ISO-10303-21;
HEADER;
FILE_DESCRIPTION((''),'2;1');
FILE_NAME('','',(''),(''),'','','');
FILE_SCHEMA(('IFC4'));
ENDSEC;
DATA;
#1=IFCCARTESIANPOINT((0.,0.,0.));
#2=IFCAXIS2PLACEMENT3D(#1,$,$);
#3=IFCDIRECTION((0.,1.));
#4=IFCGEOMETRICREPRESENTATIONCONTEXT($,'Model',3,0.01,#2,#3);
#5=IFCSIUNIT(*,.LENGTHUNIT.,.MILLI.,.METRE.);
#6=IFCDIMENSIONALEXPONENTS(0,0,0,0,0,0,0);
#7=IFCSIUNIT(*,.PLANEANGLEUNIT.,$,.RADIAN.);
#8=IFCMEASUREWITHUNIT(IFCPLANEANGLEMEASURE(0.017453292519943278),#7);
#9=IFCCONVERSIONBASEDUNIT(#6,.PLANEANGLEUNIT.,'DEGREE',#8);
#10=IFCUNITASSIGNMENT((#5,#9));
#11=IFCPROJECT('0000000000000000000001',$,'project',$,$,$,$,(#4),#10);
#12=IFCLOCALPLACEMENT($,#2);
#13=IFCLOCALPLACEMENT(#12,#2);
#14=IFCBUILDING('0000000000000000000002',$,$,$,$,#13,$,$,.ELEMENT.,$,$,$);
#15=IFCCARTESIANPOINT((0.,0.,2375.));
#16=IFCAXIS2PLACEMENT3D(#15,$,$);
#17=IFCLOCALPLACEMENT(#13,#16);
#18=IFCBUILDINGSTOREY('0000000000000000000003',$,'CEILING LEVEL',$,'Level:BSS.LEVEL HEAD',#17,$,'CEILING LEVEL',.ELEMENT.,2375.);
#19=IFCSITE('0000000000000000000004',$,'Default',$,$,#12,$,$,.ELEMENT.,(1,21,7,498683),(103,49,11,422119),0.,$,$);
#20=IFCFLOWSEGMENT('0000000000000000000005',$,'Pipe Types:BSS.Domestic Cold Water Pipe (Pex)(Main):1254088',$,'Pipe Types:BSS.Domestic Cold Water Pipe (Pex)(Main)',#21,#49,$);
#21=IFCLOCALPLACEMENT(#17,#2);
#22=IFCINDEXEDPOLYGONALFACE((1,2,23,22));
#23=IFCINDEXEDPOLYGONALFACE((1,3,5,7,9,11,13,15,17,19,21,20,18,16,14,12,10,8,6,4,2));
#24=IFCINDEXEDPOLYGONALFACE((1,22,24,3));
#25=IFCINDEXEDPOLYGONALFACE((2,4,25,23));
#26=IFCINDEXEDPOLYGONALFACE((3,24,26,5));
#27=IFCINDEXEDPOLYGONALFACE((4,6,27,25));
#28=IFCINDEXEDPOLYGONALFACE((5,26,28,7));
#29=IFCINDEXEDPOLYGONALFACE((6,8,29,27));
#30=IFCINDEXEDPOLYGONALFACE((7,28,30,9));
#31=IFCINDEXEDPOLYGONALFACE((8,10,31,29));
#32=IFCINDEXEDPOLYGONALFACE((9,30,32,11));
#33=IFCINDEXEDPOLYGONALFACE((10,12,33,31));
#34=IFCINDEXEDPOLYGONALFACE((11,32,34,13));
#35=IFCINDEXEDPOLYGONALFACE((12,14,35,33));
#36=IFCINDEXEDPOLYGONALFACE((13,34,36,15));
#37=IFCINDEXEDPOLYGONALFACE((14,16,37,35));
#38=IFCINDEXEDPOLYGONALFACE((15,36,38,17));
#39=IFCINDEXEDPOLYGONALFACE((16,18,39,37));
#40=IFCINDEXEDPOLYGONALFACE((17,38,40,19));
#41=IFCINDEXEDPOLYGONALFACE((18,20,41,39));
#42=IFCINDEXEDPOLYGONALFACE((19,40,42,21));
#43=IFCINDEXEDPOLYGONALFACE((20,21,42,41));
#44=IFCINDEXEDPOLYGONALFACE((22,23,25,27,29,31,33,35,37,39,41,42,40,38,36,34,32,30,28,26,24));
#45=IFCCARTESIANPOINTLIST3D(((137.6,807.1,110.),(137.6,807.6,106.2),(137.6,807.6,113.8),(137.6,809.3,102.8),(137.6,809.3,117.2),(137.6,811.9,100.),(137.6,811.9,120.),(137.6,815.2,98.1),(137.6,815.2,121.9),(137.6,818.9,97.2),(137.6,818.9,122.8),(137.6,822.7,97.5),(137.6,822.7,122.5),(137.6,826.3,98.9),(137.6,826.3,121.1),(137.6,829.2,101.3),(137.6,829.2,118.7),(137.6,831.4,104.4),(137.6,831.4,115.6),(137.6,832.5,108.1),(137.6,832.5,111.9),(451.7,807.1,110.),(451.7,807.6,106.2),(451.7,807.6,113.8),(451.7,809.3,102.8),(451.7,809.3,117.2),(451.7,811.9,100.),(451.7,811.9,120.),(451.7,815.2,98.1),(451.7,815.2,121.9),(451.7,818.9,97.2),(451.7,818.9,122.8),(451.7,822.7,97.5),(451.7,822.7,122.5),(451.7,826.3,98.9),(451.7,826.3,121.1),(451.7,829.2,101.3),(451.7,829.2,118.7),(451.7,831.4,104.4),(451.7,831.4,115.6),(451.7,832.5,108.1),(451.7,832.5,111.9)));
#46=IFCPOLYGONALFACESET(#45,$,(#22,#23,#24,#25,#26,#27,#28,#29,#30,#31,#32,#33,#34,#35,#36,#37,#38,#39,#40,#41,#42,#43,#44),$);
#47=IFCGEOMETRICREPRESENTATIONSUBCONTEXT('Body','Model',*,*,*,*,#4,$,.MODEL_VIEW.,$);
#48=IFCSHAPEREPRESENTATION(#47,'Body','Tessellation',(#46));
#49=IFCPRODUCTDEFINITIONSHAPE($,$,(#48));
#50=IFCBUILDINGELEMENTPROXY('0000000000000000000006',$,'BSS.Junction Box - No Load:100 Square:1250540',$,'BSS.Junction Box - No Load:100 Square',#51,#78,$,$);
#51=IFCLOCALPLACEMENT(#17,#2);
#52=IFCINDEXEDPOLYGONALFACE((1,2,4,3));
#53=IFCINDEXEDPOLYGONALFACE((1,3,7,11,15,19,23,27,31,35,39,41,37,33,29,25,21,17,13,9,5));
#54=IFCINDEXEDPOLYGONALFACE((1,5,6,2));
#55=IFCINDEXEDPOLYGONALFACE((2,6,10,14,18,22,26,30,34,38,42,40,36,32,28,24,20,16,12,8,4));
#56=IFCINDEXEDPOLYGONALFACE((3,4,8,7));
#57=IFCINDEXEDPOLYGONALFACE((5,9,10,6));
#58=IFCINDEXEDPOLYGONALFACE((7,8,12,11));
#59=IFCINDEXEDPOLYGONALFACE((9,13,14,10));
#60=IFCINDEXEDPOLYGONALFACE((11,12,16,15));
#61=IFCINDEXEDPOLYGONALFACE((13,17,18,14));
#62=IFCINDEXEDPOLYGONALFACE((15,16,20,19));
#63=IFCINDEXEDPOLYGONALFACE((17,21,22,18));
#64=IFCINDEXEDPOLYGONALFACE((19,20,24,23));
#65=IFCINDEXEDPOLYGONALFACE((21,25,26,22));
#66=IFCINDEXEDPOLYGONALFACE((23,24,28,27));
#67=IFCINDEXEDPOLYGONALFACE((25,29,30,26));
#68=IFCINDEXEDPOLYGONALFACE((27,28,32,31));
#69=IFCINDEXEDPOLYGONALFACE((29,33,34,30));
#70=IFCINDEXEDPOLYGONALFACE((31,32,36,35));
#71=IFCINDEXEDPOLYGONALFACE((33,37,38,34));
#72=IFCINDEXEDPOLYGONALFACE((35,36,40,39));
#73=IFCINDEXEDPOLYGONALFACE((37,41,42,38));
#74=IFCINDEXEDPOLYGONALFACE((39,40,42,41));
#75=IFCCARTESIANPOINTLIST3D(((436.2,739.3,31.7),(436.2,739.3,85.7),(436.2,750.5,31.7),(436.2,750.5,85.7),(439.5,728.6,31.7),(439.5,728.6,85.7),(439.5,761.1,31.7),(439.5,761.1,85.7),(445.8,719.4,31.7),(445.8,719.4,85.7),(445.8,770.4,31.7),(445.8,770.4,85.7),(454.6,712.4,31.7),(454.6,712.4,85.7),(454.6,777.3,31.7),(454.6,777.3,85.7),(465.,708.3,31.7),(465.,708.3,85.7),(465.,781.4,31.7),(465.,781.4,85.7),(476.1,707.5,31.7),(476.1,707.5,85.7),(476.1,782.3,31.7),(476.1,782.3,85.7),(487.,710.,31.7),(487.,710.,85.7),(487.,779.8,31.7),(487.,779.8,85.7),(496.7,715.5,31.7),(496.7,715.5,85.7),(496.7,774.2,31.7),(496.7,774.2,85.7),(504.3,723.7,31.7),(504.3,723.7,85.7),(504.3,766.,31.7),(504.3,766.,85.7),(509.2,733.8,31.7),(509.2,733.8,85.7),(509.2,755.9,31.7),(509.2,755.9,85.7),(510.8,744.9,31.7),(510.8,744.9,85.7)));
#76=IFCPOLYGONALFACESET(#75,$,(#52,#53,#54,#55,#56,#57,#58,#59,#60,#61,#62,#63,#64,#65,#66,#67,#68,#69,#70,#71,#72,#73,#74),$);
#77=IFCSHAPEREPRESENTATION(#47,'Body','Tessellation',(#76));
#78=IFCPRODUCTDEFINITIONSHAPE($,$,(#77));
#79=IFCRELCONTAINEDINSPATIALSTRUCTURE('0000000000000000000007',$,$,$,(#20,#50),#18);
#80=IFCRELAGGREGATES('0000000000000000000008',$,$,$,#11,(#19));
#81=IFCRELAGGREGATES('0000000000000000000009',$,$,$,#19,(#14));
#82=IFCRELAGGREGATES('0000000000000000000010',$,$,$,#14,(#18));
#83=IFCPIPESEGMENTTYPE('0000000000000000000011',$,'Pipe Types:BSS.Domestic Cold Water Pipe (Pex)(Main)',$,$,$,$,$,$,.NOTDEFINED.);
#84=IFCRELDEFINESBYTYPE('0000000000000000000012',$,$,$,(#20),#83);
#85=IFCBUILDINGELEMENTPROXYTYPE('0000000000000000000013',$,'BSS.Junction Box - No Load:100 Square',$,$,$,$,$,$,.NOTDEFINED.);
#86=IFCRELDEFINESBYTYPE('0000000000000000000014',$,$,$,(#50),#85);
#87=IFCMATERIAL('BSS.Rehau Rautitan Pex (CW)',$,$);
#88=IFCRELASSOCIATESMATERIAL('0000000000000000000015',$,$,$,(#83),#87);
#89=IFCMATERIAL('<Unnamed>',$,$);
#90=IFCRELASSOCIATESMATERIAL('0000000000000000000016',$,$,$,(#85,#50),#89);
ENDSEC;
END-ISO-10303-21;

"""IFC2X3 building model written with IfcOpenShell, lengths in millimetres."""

from ifc_helpers import new_model, entity, si_unit, converted_unit, direction, frame, frame_2d, origin, place, context, subcontext, project, spatial, circle, extrude, source, transform, mapped, material, type_object, type_shapes, element, save


model = new_model("IFC2X3")

# Units and contexts
model_context = context("Model", 3, precision=0.01, world=origin(), true_north=direction((0.0, 1.0)))
body_context = subcontext(model_context, "Body", "Model", "MODEL_VIEW")
ifc_project = project(units=[si_unit("LENGTHUNIT", "METRE", prefix="MILLI"), converted_unit("PLANEANGLEUNIT", "DEGREE", entity("IfcPlaneAngleMeasure", 0.017453292519943278), si_unit("PLANEANGLEUNIT", "RADIAN"), dimensions=[0, 0, 0, 0, 0, 0, 0])], contexts=[model_context])

# Site, building, storey
site_placement = place(None, origin())
site = spatial("IfcSite", under=ifc_project, at=site_placement, Name="Default", CompositionType="ELEMENT", RefLatitude=(1, 21, 7, 498683), RefLongitude=(103, 49, 11, 422119), RefElevation=0.0)
building_placement = place(site_placement, origin())
building = spatial("IfcBuilding", under=site, at=building_placement, CompositionType="ELEMENT")
storey_placement = place(building_placement, frame((0.0, 0.0, 2375.0)))
storey = spatial("IfcBuildingStorey", under=building, at=storey_placement, Name="CEILING LEVEL", ObjectType="Level:BSS.LEVEL HEAD", LongName="CEILING LEVEL", CompositionType="ELEMENT", Elevation=2375.0)

# Flow segment
ifc_material_1 = material(Name="BSS.Rehau Rautitan Pex (CW)")
pipe_segment_type_1 = type_object("IfcPipeSegmentType", Name="Pipe Types:BSS.Domestic Cold Water Pipe (Pex)(Main)", PredefinedType="NOTDEFINED", material=ifc_material_1)
flow_segment_1_placement = place(storey_placement, origin())
element("IfcFlowSegment", 1, at=flow_segment_1_placement, inside=storey, type_object=pipe_segment_type_1, Name="Pipe Types:BSS.Domestic Cold Water Pipe (Pex)(Main):1254088", ObjectType="Pipe Types:BSS.Domestic Cold Water Pipe (Pex)(Main)", context=body_context, shape_type="SweptSolid", body=[
    extrude(circle(Radius=12.8, at=frame_2d((0.0, 0.0), x_axis=(1.0, 0.0))), frame((137.6, 819.9, 110.0), z_axis=(1.0, 0.0, 0.0), x_axis=(0.0, -1.0, 0.0)), (0.0, 0.0, 1.0), 314.1),
])

# Building element proxy
ifc_material_2 = material(Name="<Unnamed>")
building_element_proxy_type = type_object("IfcBuildingElementProxyType", Name="BSS.Junction Box - No Load:100 Square", PredefinedType="NOTDEFINED", material=ifc_material_2)
shared_shape = source(origin(), body_context, "Body", "SweptSolid", [
    extrude(circle(Radius=37.5, at=frame_2d((0.0, 0.0), x_axis=(1.0, 0.0))), origin(), (0.0, 0.0, 1.0), 54.0),
])
type_shapes(building_element_proxy_type, [shared_shape])
proxy_placement = place(storey_placement, frame((473.3, 744.9, 31.7)))
element("IfcBuildingElementProxy", 2, at=proxy_placement, inside=storey, type_object=building_element_proxy_type, material=ifc_material_2, Name="BSS.Junction Box - No Load:100 Square:1250540", ObjectType="BSS.Junction Box - No Load:100 Square", context=body_context, shape_type="MappedRepresentation", body=[
    mapped(shared_shape, transform((0.0, 0.0, 0.0), scale=1.0)),
])

save(model, "model.ifc")
